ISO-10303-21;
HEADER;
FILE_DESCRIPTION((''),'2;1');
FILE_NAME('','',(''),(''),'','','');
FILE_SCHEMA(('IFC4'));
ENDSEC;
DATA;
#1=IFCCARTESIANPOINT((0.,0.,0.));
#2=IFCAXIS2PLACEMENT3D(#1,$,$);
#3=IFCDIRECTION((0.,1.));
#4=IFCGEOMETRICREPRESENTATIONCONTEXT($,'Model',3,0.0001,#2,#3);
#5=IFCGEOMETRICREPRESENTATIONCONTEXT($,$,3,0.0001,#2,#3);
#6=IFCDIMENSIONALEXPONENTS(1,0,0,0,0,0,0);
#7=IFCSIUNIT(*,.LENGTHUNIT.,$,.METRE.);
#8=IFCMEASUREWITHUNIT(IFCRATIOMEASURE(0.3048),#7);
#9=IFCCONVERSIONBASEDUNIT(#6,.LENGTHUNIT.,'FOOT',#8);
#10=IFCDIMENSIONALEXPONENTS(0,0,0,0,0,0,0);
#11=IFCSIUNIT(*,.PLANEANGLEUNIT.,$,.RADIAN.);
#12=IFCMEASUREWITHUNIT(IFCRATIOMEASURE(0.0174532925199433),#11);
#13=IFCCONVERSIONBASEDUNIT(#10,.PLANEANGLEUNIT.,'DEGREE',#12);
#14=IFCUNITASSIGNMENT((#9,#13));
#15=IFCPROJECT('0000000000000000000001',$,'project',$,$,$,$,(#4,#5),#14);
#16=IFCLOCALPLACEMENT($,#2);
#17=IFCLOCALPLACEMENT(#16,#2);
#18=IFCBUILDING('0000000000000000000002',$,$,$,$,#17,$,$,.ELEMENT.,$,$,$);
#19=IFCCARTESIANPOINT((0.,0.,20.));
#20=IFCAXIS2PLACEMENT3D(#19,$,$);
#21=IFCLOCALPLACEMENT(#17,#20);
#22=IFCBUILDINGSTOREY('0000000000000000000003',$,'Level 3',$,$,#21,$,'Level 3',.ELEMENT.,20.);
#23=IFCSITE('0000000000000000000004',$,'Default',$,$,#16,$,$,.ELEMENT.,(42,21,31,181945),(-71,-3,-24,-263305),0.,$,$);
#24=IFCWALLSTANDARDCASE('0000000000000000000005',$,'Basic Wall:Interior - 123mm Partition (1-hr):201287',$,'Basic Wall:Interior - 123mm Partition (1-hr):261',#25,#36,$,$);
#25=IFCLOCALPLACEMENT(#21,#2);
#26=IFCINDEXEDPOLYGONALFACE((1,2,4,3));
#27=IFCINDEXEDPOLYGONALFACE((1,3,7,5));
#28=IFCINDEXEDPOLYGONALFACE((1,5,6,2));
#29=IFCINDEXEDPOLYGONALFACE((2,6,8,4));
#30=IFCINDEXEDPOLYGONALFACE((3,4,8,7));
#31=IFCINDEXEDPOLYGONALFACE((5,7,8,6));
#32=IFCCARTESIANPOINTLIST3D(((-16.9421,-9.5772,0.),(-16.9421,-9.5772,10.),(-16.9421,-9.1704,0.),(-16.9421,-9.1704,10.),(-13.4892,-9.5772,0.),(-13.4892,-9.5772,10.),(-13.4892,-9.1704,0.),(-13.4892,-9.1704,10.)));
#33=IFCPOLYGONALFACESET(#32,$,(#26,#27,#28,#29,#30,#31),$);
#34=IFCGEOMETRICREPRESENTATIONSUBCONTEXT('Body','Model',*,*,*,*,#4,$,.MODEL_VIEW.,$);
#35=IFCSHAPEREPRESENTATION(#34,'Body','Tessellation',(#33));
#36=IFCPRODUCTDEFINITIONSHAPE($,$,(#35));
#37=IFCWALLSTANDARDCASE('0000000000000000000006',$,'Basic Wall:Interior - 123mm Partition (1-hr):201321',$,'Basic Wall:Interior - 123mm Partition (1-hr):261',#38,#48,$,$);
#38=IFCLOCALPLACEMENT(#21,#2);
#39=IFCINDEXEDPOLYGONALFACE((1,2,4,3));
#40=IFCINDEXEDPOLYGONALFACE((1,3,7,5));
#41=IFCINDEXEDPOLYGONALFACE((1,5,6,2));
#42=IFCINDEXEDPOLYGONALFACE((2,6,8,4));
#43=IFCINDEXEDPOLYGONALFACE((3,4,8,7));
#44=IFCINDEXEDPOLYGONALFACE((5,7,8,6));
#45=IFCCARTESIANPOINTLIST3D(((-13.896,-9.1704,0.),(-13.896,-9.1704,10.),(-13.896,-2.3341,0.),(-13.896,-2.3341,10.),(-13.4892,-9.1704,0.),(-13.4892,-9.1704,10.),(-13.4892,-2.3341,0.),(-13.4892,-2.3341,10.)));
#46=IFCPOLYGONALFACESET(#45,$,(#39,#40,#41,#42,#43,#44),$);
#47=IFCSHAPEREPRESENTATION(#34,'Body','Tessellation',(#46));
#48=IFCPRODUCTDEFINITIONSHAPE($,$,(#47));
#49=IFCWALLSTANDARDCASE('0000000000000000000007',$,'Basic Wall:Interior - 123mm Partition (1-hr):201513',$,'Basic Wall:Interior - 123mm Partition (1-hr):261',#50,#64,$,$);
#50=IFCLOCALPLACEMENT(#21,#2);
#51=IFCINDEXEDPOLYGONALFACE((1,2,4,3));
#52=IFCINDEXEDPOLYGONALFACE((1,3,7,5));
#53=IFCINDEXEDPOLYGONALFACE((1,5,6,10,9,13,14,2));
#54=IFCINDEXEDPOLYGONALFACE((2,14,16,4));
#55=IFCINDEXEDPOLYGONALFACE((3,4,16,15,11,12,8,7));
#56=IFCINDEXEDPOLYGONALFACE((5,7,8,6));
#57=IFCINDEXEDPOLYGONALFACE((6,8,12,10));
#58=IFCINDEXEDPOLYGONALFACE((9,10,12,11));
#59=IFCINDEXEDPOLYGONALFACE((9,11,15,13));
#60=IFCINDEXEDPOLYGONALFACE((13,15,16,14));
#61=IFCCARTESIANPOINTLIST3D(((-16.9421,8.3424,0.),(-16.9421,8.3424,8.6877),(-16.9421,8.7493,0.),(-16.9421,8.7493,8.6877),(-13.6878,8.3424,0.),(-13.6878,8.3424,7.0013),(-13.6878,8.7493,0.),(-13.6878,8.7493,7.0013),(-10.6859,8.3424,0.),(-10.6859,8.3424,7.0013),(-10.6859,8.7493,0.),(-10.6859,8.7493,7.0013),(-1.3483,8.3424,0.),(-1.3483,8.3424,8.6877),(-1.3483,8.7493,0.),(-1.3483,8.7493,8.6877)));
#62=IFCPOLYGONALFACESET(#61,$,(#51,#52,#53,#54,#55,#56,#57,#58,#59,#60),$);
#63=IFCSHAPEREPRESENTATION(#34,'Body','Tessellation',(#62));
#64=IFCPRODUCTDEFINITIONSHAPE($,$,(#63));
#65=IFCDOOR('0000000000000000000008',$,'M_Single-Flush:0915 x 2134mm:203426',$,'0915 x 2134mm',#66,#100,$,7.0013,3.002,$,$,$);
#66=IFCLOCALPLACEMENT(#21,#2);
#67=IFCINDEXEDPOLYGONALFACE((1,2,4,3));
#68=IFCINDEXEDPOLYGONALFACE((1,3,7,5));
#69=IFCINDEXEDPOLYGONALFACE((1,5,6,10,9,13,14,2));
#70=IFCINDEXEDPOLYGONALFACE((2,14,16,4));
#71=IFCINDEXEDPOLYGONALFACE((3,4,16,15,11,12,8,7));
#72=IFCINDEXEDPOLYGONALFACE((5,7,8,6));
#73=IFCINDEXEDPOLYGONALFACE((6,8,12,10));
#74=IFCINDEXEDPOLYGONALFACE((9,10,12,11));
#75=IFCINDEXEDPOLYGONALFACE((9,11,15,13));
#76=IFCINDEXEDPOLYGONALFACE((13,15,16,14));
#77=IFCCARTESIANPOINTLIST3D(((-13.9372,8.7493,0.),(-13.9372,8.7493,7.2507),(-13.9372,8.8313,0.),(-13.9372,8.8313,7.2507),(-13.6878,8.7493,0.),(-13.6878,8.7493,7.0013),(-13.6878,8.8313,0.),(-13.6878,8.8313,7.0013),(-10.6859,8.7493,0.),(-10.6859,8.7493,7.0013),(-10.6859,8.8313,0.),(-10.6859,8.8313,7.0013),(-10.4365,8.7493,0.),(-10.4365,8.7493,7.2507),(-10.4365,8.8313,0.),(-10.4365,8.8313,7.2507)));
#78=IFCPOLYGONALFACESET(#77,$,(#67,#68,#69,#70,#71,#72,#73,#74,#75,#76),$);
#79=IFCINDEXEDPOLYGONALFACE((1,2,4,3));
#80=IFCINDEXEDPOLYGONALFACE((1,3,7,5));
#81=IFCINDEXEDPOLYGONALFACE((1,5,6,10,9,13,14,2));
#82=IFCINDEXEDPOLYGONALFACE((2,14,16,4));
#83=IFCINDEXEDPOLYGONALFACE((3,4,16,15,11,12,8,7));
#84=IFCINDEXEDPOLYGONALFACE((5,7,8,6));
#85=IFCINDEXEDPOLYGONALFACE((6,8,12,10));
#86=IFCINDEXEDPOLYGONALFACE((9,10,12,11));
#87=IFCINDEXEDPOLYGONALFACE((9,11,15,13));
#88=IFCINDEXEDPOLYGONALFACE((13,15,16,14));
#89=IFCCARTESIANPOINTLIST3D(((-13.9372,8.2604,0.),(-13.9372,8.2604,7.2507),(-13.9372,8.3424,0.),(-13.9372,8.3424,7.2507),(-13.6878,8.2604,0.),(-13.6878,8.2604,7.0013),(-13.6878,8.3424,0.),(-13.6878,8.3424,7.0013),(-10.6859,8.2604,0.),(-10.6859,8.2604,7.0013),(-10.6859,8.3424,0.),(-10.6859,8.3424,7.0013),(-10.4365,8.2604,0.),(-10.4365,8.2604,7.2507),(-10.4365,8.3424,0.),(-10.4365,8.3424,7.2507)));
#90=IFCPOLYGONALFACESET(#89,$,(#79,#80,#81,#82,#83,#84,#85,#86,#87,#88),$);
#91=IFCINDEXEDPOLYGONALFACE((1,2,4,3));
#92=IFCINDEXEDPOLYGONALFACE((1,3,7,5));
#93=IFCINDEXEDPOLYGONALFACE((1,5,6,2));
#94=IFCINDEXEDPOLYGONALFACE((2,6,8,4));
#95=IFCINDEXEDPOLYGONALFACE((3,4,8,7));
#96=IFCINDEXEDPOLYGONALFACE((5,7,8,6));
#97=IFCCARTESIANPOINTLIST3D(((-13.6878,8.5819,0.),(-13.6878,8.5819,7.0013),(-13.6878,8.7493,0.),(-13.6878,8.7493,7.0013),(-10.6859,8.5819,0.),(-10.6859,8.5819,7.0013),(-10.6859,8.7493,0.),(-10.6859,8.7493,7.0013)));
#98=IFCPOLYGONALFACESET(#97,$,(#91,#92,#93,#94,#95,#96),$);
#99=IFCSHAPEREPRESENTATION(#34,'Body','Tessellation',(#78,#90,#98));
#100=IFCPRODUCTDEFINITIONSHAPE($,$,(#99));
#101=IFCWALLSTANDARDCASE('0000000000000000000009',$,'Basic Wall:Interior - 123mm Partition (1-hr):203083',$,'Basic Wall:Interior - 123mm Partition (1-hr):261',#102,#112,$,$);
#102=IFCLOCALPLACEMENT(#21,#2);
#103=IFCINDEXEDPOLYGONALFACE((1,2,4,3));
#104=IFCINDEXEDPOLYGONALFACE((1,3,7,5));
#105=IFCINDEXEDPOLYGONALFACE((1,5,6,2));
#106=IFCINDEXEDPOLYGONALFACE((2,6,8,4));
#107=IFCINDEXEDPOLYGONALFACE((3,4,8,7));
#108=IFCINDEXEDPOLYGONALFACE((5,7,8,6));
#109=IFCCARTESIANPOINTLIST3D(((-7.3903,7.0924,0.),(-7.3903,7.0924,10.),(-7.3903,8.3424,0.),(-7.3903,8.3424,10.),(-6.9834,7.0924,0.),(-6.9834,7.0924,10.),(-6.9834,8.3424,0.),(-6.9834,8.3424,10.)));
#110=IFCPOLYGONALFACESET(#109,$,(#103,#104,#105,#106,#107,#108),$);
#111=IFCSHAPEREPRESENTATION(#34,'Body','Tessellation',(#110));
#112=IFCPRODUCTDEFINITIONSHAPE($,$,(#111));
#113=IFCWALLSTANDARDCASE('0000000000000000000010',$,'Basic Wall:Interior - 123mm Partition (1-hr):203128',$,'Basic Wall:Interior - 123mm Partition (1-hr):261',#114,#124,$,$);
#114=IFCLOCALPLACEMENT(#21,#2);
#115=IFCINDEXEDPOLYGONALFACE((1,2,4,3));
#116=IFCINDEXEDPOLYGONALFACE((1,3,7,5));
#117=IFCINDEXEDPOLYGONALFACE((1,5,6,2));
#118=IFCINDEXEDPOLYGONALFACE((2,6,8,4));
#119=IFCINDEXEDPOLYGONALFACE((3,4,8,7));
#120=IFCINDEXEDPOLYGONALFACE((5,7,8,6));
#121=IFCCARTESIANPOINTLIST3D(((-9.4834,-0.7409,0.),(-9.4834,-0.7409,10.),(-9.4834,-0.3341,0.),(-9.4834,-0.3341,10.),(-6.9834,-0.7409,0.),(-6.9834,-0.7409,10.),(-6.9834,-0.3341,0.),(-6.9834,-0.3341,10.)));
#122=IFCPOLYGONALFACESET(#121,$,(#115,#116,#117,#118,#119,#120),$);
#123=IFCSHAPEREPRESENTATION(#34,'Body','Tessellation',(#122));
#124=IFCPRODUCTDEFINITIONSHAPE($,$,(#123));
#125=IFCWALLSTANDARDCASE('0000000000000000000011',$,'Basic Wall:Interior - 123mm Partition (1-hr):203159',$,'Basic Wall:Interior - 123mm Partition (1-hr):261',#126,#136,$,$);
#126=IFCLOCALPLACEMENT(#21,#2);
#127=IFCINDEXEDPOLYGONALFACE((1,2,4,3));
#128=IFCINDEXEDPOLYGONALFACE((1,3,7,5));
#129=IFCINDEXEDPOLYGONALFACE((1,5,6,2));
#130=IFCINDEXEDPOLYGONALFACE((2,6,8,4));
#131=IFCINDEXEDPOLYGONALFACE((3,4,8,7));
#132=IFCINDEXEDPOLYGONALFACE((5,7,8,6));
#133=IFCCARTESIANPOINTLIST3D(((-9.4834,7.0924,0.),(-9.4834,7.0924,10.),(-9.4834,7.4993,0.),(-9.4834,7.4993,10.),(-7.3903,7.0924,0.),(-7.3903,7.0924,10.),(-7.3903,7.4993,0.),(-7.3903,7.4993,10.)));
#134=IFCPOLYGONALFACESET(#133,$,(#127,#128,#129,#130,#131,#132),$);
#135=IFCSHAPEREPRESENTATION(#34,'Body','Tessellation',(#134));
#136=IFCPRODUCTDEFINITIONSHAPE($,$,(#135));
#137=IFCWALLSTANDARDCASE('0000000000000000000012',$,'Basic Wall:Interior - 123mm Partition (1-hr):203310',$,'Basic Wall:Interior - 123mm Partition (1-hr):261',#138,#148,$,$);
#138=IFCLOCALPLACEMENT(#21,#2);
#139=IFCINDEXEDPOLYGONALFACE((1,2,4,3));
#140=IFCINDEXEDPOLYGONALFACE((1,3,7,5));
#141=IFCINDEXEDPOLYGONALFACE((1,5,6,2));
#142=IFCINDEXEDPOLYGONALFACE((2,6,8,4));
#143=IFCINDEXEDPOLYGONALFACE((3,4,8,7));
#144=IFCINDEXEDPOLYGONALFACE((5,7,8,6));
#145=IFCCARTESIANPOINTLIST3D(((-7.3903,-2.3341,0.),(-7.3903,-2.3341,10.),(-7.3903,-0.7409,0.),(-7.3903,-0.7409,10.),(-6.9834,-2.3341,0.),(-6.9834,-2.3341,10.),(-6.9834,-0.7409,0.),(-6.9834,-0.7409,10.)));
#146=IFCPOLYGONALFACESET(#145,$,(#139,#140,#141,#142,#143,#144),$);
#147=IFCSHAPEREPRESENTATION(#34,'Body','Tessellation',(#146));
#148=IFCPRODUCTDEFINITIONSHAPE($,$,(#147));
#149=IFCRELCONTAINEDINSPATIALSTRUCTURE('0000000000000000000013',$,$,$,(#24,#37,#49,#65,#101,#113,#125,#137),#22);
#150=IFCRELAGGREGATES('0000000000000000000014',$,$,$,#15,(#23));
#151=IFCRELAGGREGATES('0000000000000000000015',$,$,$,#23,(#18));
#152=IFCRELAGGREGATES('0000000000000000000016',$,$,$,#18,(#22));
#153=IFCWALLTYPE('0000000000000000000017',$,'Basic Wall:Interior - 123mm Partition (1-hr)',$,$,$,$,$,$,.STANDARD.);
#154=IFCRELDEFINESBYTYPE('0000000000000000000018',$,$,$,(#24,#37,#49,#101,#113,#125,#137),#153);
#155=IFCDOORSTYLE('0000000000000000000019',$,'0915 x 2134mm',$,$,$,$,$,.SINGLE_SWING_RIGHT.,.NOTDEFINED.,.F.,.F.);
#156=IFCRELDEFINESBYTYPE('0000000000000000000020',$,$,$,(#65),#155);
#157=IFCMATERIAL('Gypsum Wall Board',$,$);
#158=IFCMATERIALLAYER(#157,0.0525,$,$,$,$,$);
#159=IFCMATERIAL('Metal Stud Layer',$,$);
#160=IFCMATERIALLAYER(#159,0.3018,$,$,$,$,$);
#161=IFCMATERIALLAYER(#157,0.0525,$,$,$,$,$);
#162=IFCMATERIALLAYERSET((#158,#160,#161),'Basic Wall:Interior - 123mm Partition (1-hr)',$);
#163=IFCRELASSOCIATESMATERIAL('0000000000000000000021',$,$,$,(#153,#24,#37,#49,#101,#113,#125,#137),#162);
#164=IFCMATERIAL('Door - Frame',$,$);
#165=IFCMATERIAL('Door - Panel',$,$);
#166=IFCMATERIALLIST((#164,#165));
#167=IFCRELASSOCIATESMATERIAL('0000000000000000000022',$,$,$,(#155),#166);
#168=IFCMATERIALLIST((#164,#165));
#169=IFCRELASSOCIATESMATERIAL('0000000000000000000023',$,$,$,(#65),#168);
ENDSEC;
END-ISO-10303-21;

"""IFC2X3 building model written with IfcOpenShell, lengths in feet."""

from ifc_helpers import new_model, entity, si_unit, converted_unit, direction, frame, frame_2d, origin, place, context, subcontext, project, spatial, polyline, rectangle, outline, extrude, source, transform, mapped, material, material_list, layer, layer_set, layer_usage, type_object, type_shapes, element, fill, save


model = new_model("IFC2X3")

# Units and contexts
model_context = context("Model", 3, precision=0.0001, world=origin(), true_north=direction((0.0, 1.0)))
context_of_model = context(None, 3, precision=0.0001, world=origin(), true_north=direction((0.0, 1.0)))
body_context = subcontext(model_context, "Body", "Model", "MODEL_VIEW")
ifc_project = project(units=[converted_unit("LENGTHUNIT", "FOOT", entity("IfcRatioMeasure", 0.3048), si_unit("LENGTHUNIT", "METRE"), dimensions=[1, 0, 0, 0, 0, 0, 0]), converted_unit("PLANEANGLEUNIT", "DEGREE", entity("IfcRatioMeasure", 0.0174532925199433), si_unit("PLANEANGLEUNIT", "RADIAN"), dimensions=[0, 0, 0, 0, 0, 0, 0])], contexts=[model_context, context_of_model])

# Site, building, storey
site_placement = place(None, origin())
site = spatial("IfcSite", under=ifc_project, at=site_placement, Name="Default", CompositionType="ELEMENT", RefLatitude=(42, 21, 31, 181945), RefLongitude=(-71, -3, -24, -263305), RefElevation=0.0)
building_placement = place(site_placement, origin())
building = spatial("IfcBuilding", under=site, at=building_placement, CompositionType="ELEMENT")
storey_placement = place(building_placement, frame((0.0, 0.0, 20.0)))
storey = spatial("IfcBuildingStorey", under=building, at=storey_placement, Name="Level 3", LongName="Level 3", CompositionType="ELEMENT", Elevation=20.0)

# Walls
ifc_material_1 = material(Name="Gypsum Wall Board")
ifc_layer_1 = layer(ifc_material_1, 0.0525)
ifc_material_2 = material(Name="Metal Stud Layer")
ifc_layer_2 = layer(ifc_material_2, 0.3018)
ifc_layer_3 = layer(ifc_material_1, 0.0525)
ifc_layer_set_1 = layer_set([ifc_layer_1, ifc_layer_2, ifc_layer_3], Name="Basic Wall:Interior - 123mm Partition (1-hr)")
ifc_layer_usage_1 = layer_usage(ifc_layer_set_1, "AXIS2", "NEGATIVE", 0.2034)
wall_type_1 = type_object("IfcWallType", Name="Basic Wall:Interior - 123mm Partition (1-hr)", PredefinedType="STANDARD", material=ifc_layer_set_1)
wall_1_placement = place(storey_placement, frame((-16.9421, -9.3738, 0.0)))
element("IfcWallStandardCase", 1, at=wall_1_placement, inside=storey, type_object=wall_type_1, material=ifc_layer_usage_1, Name="Basic Wall:Interior - 123mm Partition (1-hr):201287", ObjectType="Basic Wall:Interior - 123mm Partition (1-hr):261", context=body_context, shape_type="SweptSolid", body=[
    extrude(rectangle(XDim=3.4529, YDim=0.4068, at=frame_2d((1.7264, 0.0), x_axis=(-1.0, 0.0))), origin(), (0.0, 0.0, 1.0), 10.0),
])
ifc_layer_usage_2 = layer_usage(ifc_layer_set_1, "AXIS2", "NEGATIVE", 0.2034)
wall_2_placement = place(storey_placement, frame((-13.6926, -9.1704, 0.0), z_axis=(0.0, 0.0, 1.0), x_axis=(0.0, 1.0, 0.0)))
element("IfcWallStandardCase", 2, at=wall_2_placement, inside=storey, type_object=wall_type_1, material=ifc_layer_usage_2, Name="Basic Wall:Interior - 123mm Partition (1-hr):201321", ObjectType="Basic Wall:Interior - 123mm Partition (1-hr):261", context=body_context, shape_type="SweptSolid", body=[
    extrude(rectangle(XDim=6.8364, YDim=0.4068, at=frame_2d((3.4182, 0.0), x_axis=(-1.0, 0.0))), origin(), (0.0, 0.0, 1.0), 10.0),
])

# Wall, opening, door
ifc_material_3 = material(Name="Door - Frame")
ifc_material_4 = material(Name="Door - Panel")
ifc_layer_usage_3 = layer_usage(ifc_layer_set_1, "AXIS2", "NEGATIVE", 0.2034)
wall_3_placement = place(storey_placement, frame((-16.9421, 8.5459, 0.0)))
wall_3 = element("IfcWallStandardCase", 3, at=wall_3_placement, inside=storey, type_object=wall_type_1, material=ifc_layer_usage_3, Name="Basic Wall:Interior - 123mm Partition (1-hr):201513", ObjectType="Basic Wall:Interior - 123mm Partition (1-hr):261", context=body_context, shape_type="SweptSolid", body=[
    extrude(rectangle(XDim=15.5938, YDim=0.4068, at=frame_2d((7.7969, 0.0), x_axis=(-1.0, 0.0))), origin(), (0.0, 0.0, 1.0), 8.6877),
])
opening_1_placement = place(wall_3_placement, frame((3.2543, -0.2034, 0.0)))
opening_1 = element("IfcOpeningElement", 4, at=opening_1_placement, cuts=wall_3, ObjectType="Opening", context=body_context, shape_type="SweptSolid", body=[
    extrude(rectangle(XDim=3.002, YDim=7.0013, at=frame_2d((3.5007, 1.501), x_axis=(0.0, 1.0))), frame((0.0, 0.0, 0.0), z_axis=(0.0, 1.0, 0.0), x_axis=(0.0, 0.0, 1.0)), (0.0, 0.0, 1.0), 0.4068),
])
ifc_material_list_1 = material_list([ifc_material_3, ifc_material_4])
ifc_material_list_2 = material_list([ifc_material_3, ifc_material_4])
door_style_1 = type_object("IfcDoorStyle", Name="0915 x 2134mm", ConstructionType="NOTDEFINED", OperationType="SINGLE_SWING_RIGHT", ParameterTakesPrecedence=False, Sizeable=False, material=ifc_material_list_2)
shared_shape_1 = source(origin(), body_context, "Body", "SweptSolid", [
    extrude(outline(polyline([(-1.7503, -3.6877), (1.7503, -3.6877), (1.7503, 3.563), (1.501, 3.563), (1.501, -3.4383), (-1.501, -3.4383), (-1.501, 3.563), (-1.7503, 3.563), (-1.7503, -3.6877)])), frame((1.501, 0.4068, 3.563), z_axis=(0.0, 1.0, 0.0), x_axis=(1.0, 0.0, 0.0)), (0.0, 0.0, 1.0), 0.082),
    extrude(outline(polyline([(-3.6877, -1.7503), (3.563, -1.7503), (3.563, -1.501), (-3.4383, -1.501), (-3.4383, 1.501), (3.563, 1.501), (3.563, 1.7503), (-3.6877, 1.7503), (-3.6877, -1.7503)])), frame((1.501, -0.082, 3.563), z_axis=(0.0, 1.0, 0.0), x_axis=(0.0, 0.0, -1.0)), (0.0, 0.0, 1.0), 0.082),
    extrude(rectangle(XDim=0.1673, YDim=3.002, at=frame_2d((0.0, 0.0), x_axis=(1.0, 0.0))), frame((1.501, 0.3232, 0.0), z_axis=(0.0, 0.0, 1.0), x_axis=(0.0, 1.0, 0.0)), (0.0, 0.0, 1.0), 7.0013),
])
type_shapes(door_style_1, [shared_shape_1])
door_1_placement = place(opening_1_placement, origin())
door_1 = element("IfcDoor", 5, at=door_1_placement, inside=storey, type_object=door_style_1, material=ifc_material_list_1, Name="M_Single-Flush:0915 x 2134mm:203426", ObjectType="0915 x 2134mm", OverallHeight=7.0013, OverallWidth=3.002, context=body_context, shape_type="MappedRepresentation", body=[
    mapped(shared_shape_1, transform((0.0, 0.0, 0.0), scale=1.0)),
])
fill(opening_1, door_1)

# Walls
ifc_layer_usage_4 = layer_usage(ifc_layer_set_1, "AXIS2", "NEGATIVE", 0.2034)
wall_4_placement = place(storey_placement, frame((-7.1868, 8.3424, 0.0), z_axis=(0.0, 0.0, 1.0), x_axis=(0.0, -1.0, 0.0)))
element("IfcWallStandardCase", 6, at=wall_4_placement, inside=storey, type_object=wall_type_1, material=ifc_layer_usage_4, Name="Basic Wall:Interior - 123mm Partition (1-hr):203083", ObjectType="Basic Wall:Interior - 123mm Partition (1-hr):261", context=body_context, shape_type="SweptSolid", body=[
    extrude(rectangle(XDim=1.25, YDim=0.4068, at=frame_2d((0.625, 0.0), x_axis=(-1.0, 0.0))), origin(), (0.0, 0.0, 1.0), 10.0),
])
ifc_layer_usage_5 = layer_usage(ifc_layer_set_1, "AXIS2", "NEGATIVE", 0.2034)
wall_5_placement = place(storey_placement, frame((-9.4834, -0.5375, 0.0)))
element("IfcWallStandardCase", 7, at=wall_5_placement, inside=storey, type_object=wall_type_1, material=ifc_layer_usage_5, Name="Basic Wall:Interior - 123mm Partition (1-hr):203128", ObjectType="Basic Wall:Interior - 123mm Partition (1-hr):261", context=body_context, shape_type="SweptSolid", body=[
    extrude(rectangle(XDim=2.5, YDim=0.4068, at=frame_2d((1.25, 0.0), x_axis=(-1.0, 0.0))), origin(), (0.0, 0.0, 1.0), 10.0),
])
ifc_layer_usage_6 = layer_usage(ifc_layer_set_1, "AXIS2", "NEGATIVE", 0.2034)
wall_6_placement = place(storey_placement, frame((-9.4834, 7.2959, 0.0)))
element("IfcWallStandardCase", 8, at=wall_6_placement, inside=storey, type_object=wall_type_1, material=ifc_layer_usage_6, Name="Basic Wall:Interior - 123mm Partition (1-hr):203159", ObjectType="Basic Wall:Interior - 123mm Partition (1-hr):261", context=body_context, shape_type="SweptSolid", body=[
    extrude(rectangle(XDim=2.0932, YDim=0.4068, at=frame_2d((1.0466, 0.0), x_axis=(-1.0, 0.0))), origin(), (0.0, 0.0, 1.0), 10.0),
])

# Wall
ifc_layer_usage_7 = layer_usage(ifc_layer_set_1, "AXIS2", "NEGATIVE", 0.2034)
wall_7_placement = place(storey_placement, frame((-7.1868, -0.7409, 0.0), z_axis=(0.0, 0.0, 1.0), x_axis=(0.0, -1.0, 0.0)))
element("IfcWallStandardCase", 9, at=wall_7_placement, inside=storey, type_object=wall_type_1, material=ifc_layer_usage_7, Name="Basic Wall:Interior - 123mm Partition (1-hr):203310", ObjectType="Basic Wall:Interior - 123mm Partition (1-hr):261", context=body_context, shape_type="SweptSolid", body=[
    extrude(rectangle(XDim=1.5932, YDim=0.4068, at=frame_2d((0.7966, 0.0), x_axis=(-1.0, 0.0))), origin(), (0.0, 0.0, 1.0), 10.0),
])

save(model, "model.ifc")
